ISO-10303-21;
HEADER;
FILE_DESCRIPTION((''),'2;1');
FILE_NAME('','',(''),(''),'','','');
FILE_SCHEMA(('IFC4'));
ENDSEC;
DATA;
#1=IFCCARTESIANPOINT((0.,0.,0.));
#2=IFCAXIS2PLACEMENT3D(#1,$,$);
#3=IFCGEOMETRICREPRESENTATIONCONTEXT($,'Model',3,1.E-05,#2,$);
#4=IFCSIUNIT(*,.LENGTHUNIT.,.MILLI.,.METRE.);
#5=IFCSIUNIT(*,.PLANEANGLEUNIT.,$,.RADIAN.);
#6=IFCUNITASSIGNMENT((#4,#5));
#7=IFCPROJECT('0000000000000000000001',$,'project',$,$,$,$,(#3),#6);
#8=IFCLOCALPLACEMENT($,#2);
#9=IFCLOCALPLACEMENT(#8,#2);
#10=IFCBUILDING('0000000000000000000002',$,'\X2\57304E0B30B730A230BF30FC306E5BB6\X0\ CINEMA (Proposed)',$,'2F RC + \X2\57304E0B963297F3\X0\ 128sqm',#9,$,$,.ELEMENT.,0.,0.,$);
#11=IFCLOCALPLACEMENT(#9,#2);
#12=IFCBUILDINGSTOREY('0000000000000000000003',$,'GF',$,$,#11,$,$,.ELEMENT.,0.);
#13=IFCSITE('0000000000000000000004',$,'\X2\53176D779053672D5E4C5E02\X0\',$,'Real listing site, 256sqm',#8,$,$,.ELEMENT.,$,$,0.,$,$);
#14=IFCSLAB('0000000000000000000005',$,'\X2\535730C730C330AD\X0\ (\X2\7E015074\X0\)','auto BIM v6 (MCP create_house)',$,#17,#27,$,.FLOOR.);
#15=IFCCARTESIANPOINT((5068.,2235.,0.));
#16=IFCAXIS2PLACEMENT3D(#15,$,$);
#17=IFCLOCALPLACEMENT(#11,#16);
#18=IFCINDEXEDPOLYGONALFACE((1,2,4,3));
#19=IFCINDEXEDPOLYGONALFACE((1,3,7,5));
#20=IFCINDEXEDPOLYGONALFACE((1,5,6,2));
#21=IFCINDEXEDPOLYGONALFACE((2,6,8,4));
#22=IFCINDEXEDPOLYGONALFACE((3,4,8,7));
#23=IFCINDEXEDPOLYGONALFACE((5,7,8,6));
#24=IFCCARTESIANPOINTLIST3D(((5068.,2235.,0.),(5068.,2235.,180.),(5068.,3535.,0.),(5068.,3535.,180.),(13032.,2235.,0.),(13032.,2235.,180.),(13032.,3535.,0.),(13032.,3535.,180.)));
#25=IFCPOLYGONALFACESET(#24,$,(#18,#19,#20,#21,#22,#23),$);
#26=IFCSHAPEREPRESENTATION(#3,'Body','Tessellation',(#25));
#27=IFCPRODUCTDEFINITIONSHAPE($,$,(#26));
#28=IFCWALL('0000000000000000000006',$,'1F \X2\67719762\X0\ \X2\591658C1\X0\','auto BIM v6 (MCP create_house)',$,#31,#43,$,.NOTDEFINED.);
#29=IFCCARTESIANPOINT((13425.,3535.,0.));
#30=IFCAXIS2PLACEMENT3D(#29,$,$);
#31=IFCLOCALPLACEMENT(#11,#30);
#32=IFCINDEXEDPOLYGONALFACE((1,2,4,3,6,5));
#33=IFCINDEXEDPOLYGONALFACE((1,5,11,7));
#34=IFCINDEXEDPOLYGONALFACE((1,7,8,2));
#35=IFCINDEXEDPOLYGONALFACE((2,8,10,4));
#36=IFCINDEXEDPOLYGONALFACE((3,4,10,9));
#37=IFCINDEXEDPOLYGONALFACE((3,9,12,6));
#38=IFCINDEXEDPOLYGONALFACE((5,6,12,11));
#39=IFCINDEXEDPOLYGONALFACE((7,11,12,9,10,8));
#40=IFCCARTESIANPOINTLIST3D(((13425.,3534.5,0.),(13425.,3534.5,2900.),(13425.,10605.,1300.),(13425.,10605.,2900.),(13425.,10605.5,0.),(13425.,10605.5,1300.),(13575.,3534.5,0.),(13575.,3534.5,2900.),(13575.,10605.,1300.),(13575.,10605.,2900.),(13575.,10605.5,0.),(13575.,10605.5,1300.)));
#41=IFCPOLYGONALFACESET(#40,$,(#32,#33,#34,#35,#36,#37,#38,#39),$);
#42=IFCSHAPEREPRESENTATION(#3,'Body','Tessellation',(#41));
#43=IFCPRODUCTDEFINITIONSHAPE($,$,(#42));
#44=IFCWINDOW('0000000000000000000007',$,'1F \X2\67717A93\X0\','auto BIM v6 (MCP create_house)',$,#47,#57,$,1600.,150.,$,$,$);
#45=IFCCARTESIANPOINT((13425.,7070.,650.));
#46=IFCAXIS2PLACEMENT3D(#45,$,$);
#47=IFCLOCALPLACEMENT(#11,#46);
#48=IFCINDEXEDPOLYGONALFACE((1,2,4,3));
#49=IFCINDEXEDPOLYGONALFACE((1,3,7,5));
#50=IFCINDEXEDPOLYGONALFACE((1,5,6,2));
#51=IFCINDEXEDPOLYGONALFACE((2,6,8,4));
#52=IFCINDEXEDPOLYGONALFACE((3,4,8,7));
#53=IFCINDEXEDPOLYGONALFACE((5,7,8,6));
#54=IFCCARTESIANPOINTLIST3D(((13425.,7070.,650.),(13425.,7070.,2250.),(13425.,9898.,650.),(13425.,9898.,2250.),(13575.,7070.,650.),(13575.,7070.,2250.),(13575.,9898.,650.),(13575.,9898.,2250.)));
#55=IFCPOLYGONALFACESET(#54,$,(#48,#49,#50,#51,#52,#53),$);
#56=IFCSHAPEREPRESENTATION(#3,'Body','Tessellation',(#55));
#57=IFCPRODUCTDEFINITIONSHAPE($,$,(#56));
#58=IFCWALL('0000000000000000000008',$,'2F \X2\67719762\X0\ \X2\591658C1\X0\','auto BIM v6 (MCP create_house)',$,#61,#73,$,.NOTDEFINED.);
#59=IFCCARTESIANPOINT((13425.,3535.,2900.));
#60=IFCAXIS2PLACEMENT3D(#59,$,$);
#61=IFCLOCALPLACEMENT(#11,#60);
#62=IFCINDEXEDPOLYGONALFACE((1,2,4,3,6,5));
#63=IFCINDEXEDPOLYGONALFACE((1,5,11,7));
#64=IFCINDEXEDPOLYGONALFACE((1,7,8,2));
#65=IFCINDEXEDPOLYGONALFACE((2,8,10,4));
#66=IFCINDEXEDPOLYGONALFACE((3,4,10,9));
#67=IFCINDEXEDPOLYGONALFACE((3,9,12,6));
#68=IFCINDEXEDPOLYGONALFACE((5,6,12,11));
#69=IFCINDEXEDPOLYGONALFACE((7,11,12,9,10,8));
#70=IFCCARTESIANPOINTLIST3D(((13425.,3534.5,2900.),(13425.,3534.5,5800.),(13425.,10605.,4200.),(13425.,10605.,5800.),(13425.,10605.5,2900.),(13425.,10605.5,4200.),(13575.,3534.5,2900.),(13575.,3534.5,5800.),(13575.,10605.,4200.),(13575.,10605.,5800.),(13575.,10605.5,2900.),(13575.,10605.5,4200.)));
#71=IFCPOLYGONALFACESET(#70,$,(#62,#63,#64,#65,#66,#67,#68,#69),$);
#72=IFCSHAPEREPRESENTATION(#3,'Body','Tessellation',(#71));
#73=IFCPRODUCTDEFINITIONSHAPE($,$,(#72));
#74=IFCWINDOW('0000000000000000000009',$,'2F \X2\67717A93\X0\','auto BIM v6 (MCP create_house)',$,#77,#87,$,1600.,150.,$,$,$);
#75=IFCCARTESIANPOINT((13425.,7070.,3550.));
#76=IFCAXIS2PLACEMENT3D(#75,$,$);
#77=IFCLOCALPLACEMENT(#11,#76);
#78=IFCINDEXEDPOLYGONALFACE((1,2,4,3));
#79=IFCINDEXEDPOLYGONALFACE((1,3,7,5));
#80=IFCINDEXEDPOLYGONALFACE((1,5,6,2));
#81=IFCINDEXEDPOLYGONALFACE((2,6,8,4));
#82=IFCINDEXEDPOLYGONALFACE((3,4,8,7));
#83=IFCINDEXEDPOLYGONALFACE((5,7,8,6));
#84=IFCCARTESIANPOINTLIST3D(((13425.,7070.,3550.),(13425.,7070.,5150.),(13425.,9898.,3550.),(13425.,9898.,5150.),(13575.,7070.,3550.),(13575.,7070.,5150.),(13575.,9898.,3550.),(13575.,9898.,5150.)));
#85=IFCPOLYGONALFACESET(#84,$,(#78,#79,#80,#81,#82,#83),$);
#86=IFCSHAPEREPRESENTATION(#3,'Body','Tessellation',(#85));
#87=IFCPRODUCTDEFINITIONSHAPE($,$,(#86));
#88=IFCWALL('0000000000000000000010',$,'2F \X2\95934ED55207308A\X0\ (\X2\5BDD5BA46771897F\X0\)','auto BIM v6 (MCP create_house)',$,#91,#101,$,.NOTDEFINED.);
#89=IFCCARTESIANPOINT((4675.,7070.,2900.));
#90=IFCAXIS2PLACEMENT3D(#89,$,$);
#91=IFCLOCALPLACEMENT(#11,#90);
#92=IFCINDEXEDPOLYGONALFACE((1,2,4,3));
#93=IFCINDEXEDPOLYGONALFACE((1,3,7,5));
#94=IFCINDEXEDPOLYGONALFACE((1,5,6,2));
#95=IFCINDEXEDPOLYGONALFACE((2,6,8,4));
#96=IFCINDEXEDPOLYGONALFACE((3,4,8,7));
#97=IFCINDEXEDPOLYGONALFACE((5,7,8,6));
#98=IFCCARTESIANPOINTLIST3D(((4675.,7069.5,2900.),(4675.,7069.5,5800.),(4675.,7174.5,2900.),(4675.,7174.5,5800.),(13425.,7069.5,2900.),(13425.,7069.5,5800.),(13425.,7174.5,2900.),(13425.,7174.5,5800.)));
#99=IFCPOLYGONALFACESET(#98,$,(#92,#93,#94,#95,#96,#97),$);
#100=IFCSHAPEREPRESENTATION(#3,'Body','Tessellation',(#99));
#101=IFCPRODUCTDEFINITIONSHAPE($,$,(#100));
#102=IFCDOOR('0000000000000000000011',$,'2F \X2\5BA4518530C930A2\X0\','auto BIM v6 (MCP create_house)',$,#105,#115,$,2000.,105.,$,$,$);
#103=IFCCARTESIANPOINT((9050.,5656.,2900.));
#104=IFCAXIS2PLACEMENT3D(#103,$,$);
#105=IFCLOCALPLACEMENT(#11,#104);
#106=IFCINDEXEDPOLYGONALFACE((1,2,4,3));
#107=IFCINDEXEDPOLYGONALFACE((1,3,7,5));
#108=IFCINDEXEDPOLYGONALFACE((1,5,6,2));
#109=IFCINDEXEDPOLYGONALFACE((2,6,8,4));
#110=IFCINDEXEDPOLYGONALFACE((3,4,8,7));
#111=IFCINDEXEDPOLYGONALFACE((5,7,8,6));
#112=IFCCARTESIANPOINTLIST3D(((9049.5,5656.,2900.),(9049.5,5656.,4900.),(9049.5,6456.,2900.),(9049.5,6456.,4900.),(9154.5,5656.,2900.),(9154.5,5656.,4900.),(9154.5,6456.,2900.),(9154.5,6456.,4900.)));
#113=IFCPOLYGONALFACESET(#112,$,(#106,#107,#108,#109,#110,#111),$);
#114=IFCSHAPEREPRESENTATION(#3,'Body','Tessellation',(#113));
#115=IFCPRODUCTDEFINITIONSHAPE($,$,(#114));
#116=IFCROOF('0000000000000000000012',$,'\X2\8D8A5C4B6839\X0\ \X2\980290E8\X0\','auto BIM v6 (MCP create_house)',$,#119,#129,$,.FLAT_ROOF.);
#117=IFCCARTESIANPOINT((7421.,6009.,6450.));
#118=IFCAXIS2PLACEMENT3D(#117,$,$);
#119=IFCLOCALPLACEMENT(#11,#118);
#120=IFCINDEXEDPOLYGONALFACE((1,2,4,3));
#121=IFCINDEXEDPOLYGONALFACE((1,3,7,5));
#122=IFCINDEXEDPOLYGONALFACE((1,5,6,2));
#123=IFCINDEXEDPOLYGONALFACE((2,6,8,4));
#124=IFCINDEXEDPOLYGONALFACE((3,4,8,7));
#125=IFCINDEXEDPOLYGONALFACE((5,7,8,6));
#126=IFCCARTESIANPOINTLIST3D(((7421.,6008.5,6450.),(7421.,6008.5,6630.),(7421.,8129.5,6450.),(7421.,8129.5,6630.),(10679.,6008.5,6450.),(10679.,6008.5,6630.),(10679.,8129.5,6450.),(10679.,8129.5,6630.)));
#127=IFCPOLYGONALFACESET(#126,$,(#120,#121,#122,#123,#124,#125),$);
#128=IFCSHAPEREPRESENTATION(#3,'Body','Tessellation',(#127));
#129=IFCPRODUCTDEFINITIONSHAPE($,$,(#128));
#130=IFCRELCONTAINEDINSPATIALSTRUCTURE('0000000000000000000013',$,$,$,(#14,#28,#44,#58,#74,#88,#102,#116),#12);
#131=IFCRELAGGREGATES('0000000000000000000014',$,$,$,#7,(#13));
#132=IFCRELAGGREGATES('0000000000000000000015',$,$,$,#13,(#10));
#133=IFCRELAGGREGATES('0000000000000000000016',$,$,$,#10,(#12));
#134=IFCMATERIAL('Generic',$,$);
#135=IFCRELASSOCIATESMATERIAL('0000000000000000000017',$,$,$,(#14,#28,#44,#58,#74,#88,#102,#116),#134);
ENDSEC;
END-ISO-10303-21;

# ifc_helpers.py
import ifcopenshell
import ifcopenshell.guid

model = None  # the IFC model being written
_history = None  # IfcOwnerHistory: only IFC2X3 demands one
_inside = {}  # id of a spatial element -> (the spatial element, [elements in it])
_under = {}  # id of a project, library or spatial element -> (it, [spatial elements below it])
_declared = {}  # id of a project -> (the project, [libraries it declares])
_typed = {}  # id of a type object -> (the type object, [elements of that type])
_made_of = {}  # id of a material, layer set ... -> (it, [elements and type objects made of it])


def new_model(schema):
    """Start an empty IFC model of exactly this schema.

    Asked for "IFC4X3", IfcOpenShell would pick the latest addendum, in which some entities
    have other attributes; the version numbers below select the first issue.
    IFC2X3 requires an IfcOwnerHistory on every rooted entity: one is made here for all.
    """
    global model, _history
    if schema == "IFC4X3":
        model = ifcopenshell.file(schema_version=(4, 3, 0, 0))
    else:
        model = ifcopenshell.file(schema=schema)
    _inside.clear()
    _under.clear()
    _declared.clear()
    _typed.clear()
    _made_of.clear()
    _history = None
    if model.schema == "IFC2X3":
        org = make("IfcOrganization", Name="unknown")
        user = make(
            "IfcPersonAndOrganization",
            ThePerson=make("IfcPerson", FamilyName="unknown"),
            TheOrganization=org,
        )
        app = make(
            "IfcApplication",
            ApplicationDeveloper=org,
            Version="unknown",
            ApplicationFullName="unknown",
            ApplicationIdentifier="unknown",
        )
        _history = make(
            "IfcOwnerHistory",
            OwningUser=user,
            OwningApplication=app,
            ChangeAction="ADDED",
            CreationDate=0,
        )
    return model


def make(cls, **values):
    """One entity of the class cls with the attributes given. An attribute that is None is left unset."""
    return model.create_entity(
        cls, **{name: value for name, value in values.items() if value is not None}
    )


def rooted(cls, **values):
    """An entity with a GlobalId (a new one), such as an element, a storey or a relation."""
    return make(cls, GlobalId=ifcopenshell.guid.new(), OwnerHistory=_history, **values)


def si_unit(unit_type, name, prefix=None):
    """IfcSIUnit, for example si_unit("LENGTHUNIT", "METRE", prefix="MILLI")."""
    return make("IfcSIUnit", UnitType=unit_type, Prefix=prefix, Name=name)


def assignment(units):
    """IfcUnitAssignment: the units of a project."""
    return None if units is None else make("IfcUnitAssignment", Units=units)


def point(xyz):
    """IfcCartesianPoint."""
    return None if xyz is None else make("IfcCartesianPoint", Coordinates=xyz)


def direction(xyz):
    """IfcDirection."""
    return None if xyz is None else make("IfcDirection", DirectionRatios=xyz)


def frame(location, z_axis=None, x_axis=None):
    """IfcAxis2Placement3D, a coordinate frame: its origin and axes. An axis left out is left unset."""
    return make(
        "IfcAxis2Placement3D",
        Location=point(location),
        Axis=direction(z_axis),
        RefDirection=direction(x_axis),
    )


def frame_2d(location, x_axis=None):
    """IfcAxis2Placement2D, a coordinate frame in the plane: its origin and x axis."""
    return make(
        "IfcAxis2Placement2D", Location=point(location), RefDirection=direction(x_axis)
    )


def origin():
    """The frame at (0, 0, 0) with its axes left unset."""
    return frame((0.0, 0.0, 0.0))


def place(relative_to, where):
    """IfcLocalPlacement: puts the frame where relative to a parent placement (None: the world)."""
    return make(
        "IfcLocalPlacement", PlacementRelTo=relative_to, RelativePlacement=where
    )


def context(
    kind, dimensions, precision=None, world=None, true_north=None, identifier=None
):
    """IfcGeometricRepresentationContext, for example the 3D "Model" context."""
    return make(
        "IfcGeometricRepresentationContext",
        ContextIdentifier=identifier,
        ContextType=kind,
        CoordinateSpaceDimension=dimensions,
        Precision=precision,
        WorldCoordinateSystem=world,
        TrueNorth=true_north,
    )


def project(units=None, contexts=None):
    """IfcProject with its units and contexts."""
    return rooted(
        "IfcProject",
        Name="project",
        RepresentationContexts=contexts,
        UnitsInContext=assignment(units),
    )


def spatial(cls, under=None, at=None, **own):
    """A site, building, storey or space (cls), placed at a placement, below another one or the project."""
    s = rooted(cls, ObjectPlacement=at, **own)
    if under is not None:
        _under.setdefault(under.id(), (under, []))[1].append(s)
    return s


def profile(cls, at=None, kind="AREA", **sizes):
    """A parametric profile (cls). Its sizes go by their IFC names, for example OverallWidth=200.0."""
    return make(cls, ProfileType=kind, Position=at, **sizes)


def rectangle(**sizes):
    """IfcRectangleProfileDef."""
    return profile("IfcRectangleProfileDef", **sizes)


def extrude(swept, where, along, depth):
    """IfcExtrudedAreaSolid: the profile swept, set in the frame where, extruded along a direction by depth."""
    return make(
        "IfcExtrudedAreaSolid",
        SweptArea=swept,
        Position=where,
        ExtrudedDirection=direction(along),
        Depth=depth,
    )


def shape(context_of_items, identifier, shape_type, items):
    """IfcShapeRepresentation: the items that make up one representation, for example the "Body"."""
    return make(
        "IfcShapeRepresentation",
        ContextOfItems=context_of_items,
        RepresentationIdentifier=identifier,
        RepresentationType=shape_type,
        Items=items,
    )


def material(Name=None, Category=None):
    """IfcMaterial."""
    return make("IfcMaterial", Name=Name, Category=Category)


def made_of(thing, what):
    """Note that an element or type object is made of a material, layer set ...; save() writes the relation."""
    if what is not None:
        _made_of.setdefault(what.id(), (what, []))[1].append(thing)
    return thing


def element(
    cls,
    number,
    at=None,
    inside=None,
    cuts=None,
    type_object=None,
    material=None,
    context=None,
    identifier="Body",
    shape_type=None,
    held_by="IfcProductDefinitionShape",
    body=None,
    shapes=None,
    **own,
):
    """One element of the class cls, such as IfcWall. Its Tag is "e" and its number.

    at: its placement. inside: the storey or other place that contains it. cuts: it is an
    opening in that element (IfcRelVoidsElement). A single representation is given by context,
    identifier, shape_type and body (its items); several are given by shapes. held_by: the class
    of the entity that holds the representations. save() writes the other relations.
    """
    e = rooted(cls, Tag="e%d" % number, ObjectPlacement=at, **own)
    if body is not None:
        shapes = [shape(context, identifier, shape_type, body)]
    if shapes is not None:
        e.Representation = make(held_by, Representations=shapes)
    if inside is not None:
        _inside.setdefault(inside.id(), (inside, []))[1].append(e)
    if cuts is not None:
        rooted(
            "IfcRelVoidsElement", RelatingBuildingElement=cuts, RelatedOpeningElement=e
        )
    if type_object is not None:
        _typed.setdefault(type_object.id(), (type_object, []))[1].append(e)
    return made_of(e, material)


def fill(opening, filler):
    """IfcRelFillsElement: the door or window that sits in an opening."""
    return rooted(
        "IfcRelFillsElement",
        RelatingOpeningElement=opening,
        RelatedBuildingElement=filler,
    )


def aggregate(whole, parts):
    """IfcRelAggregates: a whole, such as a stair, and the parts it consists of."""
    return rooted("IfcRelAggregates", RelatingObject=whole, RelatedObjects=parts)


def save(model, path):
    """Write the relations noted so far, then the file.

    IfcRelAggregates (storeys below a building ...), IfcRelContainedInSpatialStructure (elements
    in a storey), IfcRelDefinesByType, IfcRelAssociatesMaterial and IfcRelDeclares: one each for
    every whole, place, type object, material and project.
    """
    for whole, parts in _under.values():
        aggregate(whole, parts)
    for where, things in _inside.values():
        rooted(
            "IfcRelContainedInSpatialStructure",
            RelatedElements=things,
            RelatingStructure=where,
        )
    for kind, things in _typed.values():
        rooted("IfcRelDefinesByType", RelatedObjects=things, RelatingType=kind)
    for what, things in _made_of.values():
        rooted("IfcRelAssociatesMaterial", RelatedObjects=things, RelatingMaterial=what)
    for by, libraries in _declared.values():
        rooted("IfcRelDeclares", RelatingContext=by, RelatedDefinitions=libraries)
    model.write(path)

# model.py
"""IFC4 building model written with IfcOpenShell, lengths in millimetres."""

from ifc_helpers import new_model, si_unit, frame, frame_2d, origin, place, context, project, spatial, rectangle, extrude, material, element, fill, save


model = new_model("IFC4")

# Units and contexts
model_context = context("Model", 3, precision=1e-05, world=origin())
ifc_project = project(units=[si_unit("LENGTHUNIT", "METRE", prefix="MILLI"), si_unit("PLANEANGLEUNIT", "RADIAN")], contexts=[model_context])

# Site, building, storey
site_placement = place(None, origin())
site = spatial("IfcSite", under=ifc_project, at=site_placement, Name="北海道札幌市", ObjectType="Real listing site, 256sqm", CompositionType="ELEMENT", RefElevation=0.0)
building_placement = place(site_placement, origin())
building = spatial("IfcBuilding", under=site, at=building_placement, Name="地下シアターの家 CINEMA (Proposed)", ObjectType="2F RC + 地下防音 128sqm", CompositionType="ELEMENT", ElevationOfRefHeight=0.0, ElevationOfTerrain=0.0)
storey_placement = place(building_placement, origin())
storey = spatial("IfcBuildingStorey", under=building, at=storey_placement, Name="GF", CompositionType="ELEMENT", Elevation=0.0)

# Slab
ifc_material = material(Name="Generic")
slab_placement = place(storey_placement, frame((5068.0, 2235.0, 0.0)))
element("IfcSlab", 1, at=slab_placement, inside=storey, material=ifc_material, Name="南デッキ (縁側)", Description="auto BIM v6 (MCP create_house)", PredefinedType="FLOOR", context=model_context, shape_type="SweptSolid", body=[
    extrude(rectangle(XDim=7964.0, YDim=1300.0, at=frame_2d((3982.0, 650.0))), frame((5068.0, 2235.0, 0.0)), (0.0, 0.0, 1.0), 180.0),
])

# Wall, opening, window
wall_1_placement = place(storey_placement, frame((13425.0, 3535.0, 0.0)))
wall_1 = element("IfcWall", 2, at=wall_1_placement, inside=storey, material=ifc_material, Name="1F 東面 外壁", Description="auto BIM v6 (MCP create_house)", PredefinedType="NOTDEFINED", context=model_context, shape_type="SweptSolid", body=[
    extrude(rectangle(XDim=150.0, YDim=7071.0, at=frame_2d((75.0, 3535.0))), frame((13425.0, 3535.0, 0.0)), (0.0, 0.0, 1.0), 2900.0),
])
opening_1_placement = place(storey_placement, frame((13425.0, 7070.0, 650.0)))
opening_1 = element("IfcOpeningElement", 3, at=opening_1_placement, cuts=wall_1, PredefinedType="NOTDEFINED", context=model_context, shape_type="SweptSolid", body=[
    extrude(rectangle(XDim=150.0, YDim=2828.0, at=frame_2d((75.0, 1414.0))), frame((13425.0, 7070.0, 650.0)), (0.0, 0.0, 1.0), 1600.0),
])
window_1_placement = place(storey_placement, frame((13425.0, 7070.0, 650.0)))
window_1 = element("IfcWindow", 4, at=window_1_placement, inside=storey, material=ifc_material, Name="1F 東窓", Description="auto BIM v6 (MCP create_house)", OverallHeight=1600.0, OverallWidth=150.0, context=model_context, shape_type="SweptSolid", body=[
    extrude(rectangle(XDim=150.0, YDim=2828.0, at=frame_2d((75.0, 1414.0))), frame((13425.0, 7070.0, 650.0)), (0.0, 0.0, 1.0), 1600.0),
])
fill(opening_1, window_1)

# Wall, opening, window
wall_2_placement = place(storey_placement, frame((13425.0, 3535.0, 2900.0)))
wall_2 = element("IfcWall", 5, at=wall_2_placement, inside=storey, material=ifc_material, Name="2F 東面 外壁", Description="auto BIM v6 (MCP create_house)", PredefinedType="NOTDEFINED", context=model_context, shape_type="SweptSolid", body=[
    extrude(rectangle(XDim=150.0, YDim=7071.0, at=frame_2d((75.0, 3535.0))), frame((13425.0, 3535.0, 2900.0)), (0.0, 0.0, 1.0), 2900.0),
])
opening_2_placement = place(storey_placement, frame((13425.0, 7070.0, 3550.0)))
opening_2 = element("IfcOpeningElement", 6, at=opening_2_placement, cuts=wall_2, PredefinedType="NOTDEFINED", context=model_context, shape_type="SweptSolid", body=[
    extrude(rectangle(XDim=150.0, YDim=2828.0, at=frame_2d((75.0, 1414.0))), frame((13425.0, 7070.0, 3550.0)), (0.0, 0.0, 1.0), 1600.0),
])
window_2_placement = place(storey_placement, frame((13425.0, 7070.0, 3550.0)))
window_2 = element("IfcWindow", 7, at=window_2_placement, inside=storey, material=ifc_material, Name="2F 東窓", Description="auto BIM v6 (MCP create_house)", OverallHeight=1600.0, OverallWidth=150.0, context=model_context, shape_type="SweptSolid", body=[
    extrude(rectangle(XDim=150.0, YDim=2828.0, at=frame_2d((75.0, 1414.0))), frame((13425.0, 7070.0, 3550.0)), (0.0, 0.0, 1.0), 1600.0),
])
fill(opening_2, window_2)

# Wall
wall_3_placement = place(storey_placement, frame((4675.0, 7070.0, 2900.0)))
element("IfcWall", 8, at=wall_3_placement, inside=storey, material=ifc_material, Name="2F 間仕切り (寝室東西)", Description="auto BIM v6 (MCP create_house)", PredefinedType="NOTDEFINED", context=model_context, shape_type="SweptSolid", body=[
    extrude(rectangle(XDim=8750.0, YDim=105.0, at=frame_2d((4375.0, 52.0))), frame((4675.0, 7070.0, 2900.0)), (0.0, 0.0, 1.0), 2900.0),
])

# Door
door_placement = place(storey_placement, frame((9050.0, 5656.0, 2900.0)))
element("IfcDoor", 9, at=door_placement, inside=storey, material=ifc_material, Name="2F 室内ドア", Description="auto BIM v6 (MCP create_house)", OverallHeight=2000.0, OverallWidth=105.0, context=model_context, shape_type="SweptSolid", body=[
    extrude(rectangle(XDim=105.0, YDim=800.0, at=frame_2d((52.0, 400.0))), frame((9050.0, 5656.0, 2900.0)), (0.0, 0.0, 1.0), 2000.0),
])

# Roof
roof_placement = place(storey_placement, frame((7421.0, 6009.0, 6450.0)))
element("IfcRoof", 10, at=roof_placement, inside=storey, material=ifc_material, Name="越屋根 頂部", Description="auto BIM v6 (MCP create_house)", PredefinedType="FLAT_ROOF", context=model_context, shape_type="SweptSolid", body=[
    extrude(rectangle(XDim=3258.0, YDim=2121.0, at=frame_2d((1629.0, 1060.0))), frame((7421.0, 6009.0, 6450.0)), (0.0, 0.0, 1.0), 180.0),
])

save(model, "model.ifc")
